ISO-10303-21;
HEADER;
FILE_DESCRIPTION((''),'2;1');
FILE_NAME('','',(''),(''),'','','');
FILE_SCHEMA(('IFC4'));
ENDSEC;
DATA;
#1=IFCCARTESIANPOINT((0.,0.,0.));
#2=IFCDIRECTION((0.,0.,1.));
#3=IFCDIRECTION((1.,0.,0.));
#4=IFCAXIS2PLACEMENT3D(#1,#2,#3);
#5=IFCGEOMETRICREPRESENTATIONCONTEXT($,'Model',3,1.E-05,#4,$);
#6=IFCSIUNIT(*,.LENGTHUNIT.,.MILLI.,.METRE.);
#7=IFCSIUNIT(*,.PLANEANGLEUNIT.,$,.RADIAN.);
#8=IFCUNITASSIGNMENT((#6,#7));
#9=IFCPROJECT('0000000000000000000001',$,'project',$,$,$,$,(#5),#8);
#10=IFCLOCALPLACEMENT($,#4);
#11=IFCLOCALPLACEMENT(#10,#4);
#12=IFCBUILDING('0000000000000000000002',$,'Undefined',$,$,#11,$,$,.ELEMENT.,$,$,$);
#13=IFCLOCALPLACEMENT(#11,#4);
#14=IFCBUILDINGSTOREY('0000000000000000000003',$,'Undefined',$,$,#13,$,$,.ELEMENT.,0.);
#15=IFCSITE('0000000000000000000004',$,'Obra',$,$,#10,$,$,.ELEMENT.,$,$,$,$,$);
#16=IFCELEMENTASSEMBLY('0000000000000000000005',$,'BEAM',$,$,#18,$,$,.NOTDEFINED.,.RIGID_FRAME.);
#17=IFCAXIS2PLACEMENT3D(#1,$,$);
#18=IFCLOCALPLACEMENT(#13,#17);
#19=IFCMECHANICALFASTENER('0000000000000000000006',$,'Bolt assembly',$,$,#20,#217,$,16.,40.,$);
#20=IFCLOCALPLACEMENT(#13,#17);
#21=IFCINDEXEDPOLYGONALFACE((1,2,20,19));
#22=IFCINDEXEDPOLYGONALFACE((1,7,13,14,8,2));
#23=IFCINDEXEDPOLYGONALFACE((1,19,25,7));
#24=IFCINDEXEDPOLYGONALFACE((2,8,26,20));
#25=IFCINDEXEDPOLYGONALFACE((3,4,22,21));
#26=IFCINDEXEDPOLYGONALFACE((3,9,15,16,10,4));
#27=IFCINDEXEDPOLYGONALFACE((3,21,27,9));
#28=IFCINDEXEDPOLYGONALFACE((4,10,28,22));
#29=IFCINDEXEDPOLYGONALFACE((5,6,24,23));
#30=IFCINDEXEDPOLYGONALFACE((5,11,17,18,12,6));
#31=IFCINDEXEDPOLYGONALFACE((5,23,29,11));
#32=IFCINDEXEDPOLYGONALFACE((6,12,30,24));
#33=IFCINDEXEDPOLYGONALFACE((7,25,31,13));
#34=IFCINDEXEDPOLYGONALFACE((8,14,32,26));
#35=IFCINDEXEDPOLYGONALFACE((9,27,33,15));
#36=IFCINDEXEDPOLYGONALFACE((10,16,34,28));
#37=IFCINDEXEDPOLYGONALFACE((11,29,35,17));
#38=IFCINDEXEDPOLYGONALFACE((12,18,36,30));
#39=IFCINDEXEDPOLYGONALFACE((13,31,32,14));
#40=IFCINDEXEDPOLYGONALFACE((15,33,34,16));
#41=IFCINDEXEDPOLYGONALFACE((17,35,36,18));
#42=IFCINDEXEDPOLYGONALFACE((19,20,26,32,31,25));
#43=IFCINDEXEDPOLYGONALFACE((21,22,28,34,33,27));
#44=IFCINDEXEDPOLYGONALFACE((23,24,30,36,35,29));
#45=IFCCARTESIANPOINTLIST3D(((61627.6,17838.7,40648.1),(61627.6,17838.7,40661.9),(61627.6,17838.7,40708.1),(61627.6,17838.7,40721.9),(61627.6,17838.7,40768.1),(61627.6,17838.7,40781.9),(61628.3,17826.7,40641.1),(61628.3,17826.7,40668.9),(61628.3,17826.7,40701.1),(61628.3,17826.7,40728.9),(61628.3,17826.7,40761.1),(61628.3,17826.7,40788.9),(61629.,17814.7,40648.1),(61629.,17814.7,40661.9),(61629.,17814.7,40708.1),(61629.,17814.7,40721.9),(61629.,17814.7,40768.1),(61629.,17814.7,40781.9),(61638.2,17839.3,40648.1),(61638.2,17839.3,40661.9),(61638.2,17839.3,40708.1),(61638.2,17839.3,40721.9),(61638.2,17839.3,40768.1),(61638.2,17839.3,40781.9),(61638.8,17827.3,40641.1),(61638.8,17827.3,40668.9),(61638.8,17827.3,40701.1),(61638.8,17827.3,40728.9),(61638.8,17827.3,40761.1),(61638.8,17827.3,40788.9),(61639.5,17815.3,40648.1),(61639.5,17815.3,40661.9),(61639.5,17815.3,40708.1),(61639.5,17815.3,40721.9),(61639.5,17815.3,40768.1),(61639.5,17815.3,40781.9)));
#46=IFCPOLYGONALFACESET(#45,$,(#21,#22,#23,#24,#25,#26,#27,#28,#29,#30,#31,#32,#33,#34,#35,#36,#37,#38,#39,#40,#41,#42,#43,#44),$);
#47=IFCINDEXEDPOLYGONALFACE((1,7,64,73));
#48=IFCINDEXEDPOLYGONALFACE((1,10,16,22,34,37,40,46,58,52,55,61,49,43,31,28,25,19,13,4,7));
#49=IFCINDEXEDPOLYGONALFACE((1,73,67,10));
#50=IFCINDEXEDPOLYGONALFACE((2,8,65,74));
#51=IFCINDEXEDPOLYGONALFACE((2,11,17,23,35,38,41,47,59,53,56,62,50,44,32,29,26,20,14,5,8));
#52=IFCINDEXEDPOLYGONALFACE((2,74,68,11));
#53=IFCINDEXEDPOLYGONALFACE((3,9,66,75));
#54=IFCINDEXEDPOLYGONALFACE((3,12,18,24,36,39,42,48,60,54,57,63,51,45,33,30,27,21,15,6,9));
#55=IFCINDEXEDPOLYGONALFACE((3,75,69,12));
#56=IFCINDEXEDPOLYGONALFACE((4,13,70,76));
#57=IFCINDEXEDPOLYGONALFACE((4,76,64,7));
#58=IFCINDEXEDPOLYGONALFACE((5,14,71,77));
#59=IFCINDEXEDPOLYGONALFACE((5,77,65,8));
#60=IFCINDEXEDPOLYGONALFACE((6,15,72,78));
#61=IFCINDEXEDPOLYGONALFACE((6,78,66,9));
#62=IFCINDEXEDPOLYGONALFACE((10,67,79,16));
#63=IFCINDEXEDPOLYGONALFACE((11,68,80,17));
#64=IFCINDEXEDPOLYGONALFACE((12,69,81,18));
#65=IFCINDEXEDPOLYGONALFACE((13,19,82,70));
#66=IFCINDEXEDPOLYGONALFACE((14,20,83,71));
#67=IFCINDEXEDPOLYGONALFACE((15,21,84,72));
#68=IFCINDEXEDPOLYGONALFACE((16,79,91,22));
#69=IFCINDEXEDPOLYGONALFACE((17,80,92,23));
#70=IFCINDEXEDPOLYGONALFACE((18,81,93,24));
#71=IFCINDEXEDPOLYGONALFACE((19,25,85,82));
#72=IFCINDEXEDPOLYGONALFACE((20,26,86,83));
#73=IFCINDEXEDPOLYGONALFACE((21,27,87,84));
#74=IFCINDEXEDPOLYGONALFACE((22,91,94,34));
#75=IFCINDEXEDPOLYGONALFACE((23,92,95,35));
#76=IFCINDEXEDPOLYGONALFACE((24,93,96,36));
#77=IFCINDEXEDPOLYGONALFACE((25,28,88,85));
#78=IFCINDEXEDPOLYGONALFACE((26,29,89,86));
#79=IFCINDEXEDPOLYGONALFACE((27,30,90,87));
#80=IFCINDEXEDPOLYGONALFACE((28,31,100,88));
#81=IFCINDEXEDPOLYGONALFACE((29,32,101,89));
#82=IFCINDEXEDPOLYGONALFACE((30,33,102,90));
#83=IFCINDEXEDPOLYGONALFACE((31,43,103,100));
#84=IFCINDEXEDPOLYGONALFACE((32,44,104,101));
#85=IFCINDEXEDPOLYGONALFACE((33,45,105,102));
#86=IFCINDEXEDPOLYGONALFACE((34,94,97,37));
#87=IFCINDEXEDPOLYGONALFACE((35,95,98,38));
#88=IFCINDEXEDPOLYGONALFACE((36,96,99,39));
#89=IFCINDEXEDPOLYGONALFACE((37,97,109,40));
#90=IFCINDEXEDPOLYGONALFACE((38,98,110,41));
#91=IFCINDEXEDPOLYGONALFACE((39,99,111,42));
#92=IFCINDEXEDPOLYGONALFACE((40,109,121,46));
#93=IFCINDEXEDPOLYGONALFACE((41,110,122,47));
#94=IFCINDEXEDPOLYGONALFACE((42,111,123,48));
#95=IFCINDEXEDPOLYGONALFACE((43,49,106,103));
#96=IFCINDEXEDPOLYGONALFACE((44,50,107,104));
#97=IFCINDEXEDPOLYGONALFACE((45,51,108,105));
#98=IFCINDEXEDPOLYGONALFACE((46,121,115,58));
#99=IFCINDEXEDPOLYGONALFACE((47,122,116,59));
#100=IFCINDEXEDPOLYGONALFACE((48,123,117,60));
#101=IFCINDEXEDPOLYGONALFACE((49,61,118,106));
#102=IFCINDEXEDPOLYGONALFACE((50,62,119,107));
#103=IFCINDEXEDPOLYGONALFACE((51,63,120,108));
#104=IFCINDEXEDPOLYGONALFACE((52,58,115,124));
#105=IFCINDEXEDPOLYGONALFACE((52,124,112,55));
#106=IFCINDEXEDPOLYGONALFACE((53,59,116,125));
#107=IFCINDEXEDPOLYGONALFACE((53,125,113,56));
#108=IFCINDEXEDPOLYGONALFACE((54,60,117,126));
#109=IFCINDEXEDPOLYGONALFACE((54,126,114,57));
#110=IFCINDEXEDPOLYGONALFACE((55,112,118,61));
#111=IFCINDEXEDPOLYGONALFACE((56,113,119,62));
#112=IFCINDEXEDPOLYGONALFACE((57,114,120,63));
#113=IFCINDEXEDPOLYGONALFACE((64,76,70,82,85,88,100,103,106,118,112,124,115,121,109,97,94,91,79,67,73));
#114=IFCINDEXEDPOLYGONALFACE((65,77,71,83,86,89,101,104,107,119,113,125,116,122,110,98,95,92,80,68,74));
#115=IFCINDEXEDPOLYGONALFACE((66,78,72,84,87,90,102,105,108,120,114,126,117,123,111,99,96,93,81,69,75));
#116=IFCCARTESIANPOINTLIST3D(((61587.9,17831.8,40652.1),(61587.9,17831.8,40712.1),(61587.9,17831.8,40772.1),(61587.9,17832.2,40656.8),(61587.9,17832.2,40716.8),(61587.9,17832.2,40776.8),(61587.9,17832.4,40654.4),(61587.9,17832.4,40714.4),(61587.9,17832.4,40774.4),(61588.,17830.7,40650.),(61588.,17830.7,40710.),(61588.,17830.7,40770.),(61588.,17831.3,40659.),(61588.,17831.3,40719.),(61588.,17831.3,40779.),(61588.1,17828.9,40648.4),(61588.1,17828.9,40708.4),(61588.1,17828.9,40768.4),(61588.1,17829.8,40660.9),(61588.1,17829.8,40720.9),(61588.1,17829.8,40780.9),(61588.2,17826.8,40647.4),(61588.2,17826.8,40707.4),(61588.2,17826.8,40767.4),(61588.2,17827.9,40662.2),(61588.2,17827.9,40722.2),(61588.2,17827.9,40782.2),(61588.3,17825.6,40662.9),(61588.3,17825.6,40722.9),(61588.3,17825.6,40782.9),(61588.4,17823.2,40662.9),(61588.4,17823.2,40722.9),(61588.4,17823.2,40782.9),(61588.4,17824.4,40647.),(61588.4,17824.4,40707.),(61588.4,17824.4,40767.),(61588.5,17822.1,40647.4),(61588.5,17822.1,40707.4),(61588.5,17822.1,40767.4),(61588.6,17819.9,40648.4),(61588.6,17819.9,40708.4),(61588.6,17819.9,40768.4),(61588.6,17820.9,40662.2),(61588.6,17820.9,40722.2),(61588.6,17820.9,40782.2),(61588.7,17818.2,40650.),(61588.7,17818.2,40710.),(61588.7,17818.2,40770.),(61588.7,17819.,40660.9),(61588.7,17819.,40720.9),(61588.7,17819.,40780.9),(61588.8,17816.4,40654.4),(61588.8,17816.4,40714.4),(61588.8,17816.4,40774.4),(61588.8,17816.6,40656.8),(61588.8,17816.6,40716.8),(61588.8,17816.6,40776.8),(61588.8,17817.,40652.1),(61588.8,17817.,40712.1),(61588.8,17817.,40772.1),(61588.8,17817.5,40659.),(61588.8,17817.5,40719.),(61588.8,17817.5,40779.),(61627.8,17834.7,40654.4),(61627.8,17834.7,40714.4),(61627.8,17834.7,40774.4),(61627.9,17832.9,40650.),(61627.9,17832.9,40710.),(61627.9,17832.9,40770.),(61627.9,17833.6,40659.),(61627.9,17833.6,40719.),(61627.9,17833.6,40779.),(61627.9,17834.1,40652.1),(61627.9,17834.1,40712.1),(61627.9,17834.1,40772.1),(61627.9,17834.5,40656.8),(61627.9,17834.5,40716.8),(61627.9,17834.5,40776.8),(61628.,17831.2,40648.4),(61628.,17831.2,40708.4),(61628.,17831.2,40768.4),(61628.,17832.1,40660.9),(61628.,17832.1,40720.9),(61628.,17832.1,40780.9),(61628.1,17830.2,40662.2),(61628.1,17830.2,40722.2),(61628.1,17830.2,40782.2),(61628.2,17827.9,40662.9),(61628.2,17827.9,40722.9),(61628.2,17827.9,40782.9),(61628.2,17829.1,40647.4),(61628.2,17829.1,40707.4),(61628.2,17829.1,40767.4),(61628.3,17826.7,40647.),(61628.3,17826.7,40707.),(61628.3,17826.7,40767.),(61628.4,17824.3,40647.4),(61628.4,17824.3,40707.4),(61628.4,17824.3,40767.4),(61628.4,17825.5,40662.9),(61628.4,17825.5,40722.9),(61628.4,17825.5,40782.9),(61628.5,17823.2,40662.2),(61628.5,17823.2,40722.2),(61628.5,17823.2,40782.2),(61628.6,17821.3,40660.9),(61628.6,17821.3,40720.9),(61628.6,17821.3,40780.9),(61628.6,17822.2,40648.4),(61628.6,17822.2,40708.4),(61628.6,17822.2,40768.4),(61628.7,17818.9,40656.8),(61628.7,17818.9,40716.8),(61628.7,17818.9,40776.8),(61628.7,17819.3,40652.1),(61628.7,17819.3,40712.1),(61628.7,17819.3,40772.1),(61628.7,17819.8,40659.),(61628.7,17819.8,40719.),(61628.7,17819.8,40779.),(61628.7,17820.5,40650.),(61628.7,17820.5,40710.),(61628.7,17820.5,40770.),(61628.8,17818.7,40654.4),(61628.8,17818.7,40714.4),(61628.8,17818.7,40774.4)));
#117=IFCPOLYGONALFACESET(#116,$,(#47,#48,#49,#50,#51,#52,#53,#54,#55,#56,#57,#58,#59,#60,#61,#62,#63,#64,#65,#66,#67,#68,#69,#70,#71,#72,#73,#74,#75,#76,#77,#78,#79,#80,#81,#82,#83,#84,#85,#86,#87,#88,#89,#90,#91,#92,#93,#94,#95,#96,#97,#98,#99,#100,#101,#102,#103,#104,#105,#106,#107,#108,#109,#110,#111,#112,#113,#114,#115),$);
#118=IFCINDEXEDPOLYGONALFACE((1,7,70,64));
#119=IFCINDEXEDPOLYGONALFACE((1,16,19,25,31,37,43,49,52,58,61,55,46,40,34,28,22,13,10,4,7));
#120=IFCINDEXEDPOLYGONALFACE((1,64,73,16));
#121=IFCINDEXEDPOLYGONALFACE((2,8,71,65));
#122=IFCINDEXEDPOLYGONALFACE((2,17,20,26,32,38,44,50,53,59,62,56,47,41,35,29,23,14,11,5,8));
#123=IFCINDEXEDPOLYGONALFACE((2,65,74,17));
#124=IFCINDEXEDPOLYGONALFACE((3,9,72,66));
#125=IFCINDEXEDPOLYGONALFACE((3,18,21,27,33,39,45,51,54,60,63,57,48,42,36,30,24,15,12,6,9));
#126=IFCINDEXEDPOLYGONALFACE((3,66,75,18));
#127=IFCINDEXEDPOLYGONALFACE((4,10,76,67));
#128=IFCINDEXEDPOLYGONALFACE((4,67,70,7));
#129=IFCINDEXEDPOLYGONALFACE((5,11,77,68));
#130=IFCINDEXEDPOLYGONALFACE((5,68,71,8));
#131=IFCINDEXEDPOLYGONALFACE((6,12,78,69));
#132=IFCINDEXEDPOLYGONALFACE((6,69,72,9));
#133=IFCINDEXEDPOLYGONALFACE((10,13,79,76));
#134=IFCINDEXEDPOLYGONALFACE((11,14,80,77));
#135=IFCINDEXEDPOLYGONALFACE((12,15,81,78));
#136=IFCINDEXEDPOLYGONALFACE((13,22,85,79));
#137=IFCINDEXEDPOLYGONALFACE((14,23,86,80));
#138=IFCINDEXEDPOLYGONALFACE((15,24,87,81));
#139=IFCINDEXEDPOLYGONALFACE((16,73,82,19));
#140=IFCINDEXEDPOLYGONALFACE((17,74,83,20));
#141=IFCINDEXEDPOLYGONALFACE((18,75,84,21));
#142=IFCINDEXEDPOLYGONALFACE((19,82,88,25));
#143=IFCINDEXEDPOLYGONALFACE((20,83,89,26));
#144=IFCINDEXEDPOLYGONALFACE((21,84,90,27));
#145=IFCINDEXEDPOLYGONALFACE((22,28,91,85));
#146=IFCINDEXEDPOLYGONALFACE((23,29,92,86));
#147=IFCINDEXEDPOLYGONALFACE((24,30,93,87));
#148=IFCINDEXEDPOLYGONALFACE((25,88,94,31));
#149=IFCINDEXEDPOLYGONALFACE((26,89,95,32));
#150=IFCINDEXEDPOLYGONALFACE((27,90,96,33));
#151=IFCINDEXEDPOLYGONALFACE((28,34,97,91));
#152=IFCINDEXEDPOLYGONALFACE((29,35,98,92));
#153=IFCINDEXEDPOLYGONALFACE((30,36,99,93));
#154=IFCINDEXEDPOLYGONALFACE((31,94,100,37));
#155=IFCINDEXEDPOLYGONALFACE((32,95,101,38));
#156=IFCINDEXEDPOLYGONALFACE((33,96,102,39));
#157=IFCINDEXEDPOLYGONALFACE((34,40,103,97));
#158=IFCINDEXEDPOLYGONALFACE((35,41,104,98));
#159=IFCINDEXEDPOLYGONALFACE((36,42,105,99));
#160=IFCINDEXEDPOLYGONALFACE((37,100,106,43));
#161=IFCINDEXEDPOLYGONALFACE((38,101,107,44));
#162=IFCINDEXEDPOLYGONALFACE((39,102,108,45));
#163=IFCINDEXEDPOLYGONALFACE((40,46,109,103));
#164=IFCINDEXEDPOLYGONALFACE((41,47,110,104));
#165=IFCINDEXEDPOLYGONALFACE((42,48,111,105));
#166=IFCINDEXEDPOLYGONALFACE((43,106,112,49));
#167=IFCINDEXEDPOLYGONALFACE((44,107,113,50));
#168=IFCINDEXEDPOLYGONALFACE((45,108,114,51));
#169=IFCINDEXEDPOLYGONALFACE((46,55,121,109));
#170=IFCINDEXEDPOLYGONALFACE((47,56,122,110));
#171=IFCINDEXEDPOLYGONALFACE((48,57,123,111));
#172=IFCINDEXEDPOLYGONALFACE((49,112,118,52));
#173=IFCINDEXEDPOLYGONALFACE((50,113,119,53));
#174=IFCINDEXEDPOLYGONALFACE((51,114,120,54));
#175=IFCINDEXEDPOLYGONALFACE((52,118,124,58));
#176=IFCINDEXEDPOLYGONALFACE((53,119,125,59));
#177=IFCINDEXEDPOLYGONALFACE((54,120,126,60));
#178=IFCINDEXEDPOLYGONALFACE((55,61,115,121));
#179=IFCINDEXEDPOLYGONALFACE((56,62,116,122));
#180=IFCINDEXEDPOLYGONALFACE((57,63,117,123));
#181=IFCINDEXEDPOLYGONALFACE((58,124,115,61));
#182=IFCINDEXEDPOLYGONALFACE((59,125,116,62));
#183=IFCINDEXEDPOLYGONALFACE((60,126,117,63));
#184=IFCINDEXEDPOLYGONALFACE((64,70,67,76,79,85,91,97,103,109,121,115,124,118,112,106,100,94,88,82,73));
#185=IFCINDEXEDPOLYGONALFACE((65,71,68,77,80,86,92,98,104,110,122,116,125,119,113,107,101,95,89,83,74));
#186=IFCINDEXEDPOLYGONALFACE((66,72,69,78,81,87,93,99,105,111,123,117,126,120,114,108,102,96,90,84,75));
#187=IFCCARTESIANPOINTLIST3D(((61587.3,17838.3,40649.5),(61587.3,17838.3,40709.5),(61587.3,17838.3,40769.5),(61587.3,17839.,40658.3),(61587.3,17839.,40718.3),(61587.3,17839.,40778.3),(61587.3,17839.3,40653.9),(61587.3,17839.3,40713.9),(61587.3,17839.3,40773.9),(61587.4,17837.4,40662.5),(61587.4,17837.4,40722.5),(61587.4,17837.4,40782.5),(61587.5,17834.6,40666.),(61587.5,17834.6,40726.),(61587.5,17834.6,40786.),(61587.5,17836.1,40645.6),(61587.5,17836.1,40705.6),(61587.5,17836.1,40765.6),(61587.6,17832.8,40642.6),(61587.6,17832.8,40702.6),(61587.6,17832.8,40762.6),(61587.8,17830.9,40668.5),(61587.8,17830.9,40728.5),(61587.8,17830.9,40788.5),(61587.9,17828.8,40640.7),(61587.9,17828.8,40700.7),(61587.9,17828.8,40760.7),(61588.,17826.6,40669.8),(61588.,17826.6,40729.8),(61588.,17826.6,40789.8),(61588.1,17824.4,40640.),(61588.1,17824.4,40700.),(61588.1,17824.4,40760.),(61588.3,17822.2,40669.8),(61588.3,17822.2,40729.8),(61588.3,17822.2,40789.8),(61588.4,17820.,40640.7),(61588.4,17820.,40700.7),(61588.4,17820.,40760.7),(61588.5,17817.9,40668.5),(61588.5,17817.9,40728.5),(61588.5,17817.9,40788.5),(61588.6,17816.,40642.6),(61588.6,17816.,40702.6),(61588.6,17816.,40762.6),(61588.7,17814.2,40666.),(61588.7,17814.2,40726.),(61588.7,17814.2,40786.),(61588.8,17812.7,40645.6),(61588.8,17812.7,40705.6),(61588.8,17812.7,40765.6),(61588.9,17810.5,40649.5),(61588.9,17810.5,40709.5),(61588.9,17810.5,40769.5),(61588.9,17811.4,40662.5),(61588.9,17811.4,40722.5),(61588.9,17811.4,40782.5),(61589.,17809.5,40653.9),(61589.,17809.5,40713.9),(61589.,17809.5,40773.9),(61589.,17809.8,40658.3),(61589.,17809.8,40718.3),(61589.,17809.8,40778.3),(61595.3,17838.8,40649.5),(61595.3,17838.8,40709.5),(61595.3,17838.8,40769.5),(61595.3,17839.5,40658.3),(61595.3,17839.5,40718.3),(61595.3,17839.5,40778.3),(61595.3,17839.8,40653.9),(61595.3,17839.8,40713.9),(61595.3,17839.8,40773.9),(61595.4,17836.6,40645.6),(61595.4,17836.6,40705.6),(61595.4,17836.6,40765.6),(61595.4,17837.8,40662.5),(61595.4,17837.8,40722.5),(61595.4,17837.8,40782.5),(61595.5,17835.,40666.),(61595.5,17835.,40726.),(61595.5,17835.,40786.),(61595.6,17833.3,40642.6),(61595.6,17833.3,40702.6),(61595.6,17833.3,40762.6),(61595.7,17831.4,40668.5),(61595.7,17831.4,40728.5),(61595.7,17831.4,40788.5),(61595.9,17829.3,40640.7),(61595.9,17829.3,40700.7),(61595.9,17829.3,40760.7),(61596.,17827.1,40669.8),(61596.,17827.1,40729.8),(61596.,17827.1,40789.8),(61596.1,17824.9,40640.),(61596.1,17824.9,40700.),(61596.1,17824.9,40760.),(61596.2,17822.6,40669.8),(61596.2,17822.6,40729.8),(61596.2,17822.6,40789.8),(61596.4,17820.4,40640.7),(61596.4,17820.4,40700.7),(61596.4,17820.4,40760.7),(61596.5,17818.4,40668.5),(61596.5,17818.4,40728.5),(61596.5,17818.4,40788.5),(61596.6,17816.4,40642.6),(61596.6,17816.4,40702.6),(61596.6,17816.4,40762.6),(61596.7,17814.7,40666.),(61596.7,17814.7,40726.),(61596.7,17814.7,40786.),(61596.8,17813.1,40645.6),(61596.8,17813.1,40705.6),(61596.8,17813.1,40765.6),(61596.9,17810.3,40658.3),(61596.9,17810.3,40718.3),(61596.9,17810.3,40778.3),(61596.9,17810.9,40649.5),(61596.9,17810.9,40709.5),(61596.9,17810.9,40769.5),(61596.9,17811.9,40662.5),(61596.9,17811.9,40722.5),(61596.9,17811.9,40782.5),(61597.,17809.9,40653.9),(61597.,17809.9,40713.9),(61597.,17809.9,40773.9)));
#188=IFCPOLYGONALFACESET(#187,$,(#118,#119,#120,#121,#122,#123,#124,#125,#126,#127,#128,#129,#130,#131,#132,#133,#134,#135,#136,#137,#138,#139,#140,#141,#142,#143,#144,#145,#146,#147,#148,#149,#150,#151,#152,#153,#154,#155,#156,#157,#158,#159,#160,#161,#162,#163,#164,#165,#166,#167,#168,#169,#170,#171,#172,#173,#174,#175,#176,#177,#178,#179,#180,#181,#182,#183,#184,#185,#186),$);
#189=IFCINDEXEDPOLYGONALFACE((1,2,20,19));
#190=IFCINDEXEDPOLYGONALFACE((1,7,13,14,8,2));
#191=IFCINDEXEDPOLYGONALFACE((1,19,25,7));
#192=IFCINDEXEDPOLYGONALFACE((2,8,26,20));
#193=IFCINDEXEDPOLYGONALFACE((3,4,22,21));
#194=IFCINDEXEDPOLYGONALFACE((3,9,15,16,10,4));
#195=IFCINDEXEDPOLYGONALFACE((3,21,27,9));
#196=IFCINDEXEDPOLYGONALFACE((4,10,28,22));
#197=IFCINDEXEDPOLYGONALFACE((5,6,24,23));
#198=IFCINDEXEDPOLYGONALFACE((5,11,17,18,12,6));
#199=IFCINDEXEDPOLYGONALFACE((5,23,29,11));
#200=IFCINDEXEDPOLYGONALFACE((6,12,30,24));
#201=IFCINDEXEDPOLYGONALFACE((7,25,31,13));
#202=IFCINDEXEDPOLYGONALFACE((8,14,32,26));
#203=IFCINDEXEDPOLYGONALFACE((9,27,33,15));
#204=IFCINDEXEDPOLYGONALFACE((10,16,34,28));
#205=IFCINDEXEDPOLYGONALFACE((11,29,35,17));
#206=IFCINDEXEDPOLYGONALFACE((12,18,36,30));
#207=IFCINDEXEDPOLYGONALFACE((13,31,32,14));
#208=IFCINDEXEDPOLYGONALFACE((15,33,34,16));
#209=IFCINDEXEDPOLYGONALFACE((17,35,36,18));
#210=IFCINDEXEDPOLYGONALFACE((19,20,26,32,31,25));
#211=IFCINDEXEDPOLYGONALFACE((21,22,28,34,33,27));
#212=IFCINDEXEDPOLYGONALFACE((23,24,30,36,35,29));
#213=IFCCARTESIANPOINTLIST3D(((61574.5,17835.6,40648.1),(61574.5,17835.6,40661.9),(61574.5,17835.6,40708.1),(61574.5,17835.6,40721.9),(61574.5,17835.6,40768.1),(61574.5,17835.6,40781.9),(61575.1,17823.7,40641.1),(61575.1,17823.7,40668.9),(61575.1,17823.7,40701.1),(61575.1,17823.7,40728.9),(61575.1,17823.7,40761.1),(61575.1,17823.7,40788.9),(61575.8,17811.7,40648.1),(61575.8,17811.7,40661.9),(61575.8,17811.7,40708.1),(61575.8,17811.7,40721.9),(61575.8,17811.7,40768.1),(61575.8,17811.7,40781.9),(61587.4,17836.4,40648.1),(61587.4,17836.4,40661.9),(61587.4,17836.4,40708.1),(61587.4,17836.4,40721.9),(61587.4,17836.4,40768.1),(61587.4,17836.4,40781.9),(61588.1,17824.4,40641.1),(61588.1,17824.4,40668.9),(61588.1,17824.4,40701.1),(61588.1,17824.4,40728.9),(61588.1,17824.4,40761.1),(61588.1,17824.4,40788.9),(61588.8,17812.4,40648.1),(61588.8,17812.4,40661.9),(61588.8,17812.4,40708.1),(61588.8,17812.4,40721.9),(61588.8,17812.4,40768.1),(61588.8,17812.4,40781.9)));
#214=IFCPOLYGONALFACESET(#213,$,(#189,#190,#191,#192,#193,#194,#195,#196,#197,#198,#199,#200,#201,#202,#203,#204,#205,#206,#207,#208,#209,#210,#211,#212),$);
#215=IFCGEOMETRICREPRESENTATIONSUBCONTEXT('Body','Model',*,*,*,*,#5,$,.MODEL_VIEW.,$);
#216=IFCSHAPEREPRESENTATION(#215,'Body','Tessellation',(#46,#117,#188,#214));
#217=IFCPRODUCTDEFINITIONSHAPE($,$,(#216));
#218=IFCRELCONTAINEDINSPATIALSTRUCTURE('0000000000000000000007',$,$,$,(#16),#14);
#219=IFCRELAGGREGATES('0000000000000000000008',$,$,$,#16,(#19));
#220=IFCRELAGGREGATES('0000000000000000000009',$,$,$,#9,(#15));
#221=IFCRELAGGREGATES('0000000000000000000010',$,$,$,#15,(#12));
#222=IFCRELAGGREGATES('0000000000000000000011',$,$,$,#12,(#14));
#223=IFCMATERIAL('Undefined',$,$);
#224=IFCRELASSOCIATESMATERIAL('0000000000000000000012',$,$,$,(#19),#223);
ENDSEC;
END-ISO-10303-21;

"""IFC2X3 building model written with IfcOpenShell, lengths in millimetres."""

from ifc_helpers import new_model, si_unit, frame, origin_with_axes, origin_2d_with_axis, place, context, subcontext, project, spatial, polyline, circle, outline, extrude, source, transform, mapped, material, element, aggregate, save


model = new_model("IFC2X3")

# Units and contexts
model_context = context("Model", 3, precision=1e-05, world=origin_with_axes())
body_context = subcontext(model_context, "Body", "Model", "MODEL_VIEW")
ifc_project = project(units=[si_unit("LENGTHUNIT", "METRE", prefix="MILLI"), si_unit("PLANEANGLEUNIT", "RADIAN")], contexts=[model_context])

# Site, building, storey
site_placement = place(None, origin_with_axes())
site = spatial("IfcSite", under=ifc_project, at=site_placement, Name="Obra", CompositionType="ELEMENT")
building_placement = place(site_placement, origin_with_axes())
building = spatial("IfcBuilding", under=site, at=building_placement, Name="Undefined", CompositionType="ELEMENT")
storey_placement = place(building_placement, origin_with_axes())
storey = spatial("IfcBuildingStorey", under=building, at=storey_placement, Name="Undefined", CompositionType="ELEMENT", Elevation=0.0)

# Element assembly
assembly_1_placement = place(storey_placement, origin_with_axes())
assembly_1 = element("IfcElementAssembly", 1, at=assembly_1_placement, inside=storey, Name="BEAM", AssemblyPlace="NOTDEFINED", PredefinedType="RIGID_FRAME")

# Mechanical fastener
ifc_material_1 = material(Name="Undefined")
shared_shape_1 = source(origin_with_axes(), body_context, "Body", "SweptSolid", [
    extrude(outline(polyline([(13.9, 0.0), (6.9, 12.0), (-6.9, 12.0), (-13.9, 0.0), (-6.9, -12.0), (6.9, -12.0), (13.9, 0.0)])), frame((0.0, -45.9, 0.0), z_axis=(0.0, 1.0, 0.0), x_axis=(1.0, 0.0, 0.0)), (0.0, 0.0, 1.0), 10.6),
    extrude(circle(Radius=8.0, at=origin_2d_with_axis()), frame((0.0, -35.3, 0.0), z_axis=(0.0, 1.0, 0.0), x_axis=(1.0, 0.0, 0.0)), (0.0, 0.0, 1.0), 40.0),
    extrude(circle(Radius=15.0, at=origin_2d_with_axis()), frame((0.0, -3.1, 0.0), z_axis=(0.0, 1.0, 0.0), x_axis=(1.0, 0.0, 0.0)), (0.0, 0.0, 1.0), 8.0),
    extrude(outline(polyline([(13.9, 0.0), (6.9, 12.0), (-6.9, 12.0), (-13.9, 0.0), (-6.9, -12.0), (6.9, -12.0), (13.9, 0.0)])), frame((0.0, 4.9, 0.0), z_axis=(0.0, 1.0, 0.0), x_axis=(1.0, 0.0, 0.0)), (0.0, 0.0, 1.0), 13.0),
])
mechanical_fastener_1_placement = place(assembly_1_placement, frame((61595.9, 17774.8, 40835.0), z_axis=(-0.057107, 0.998368, 0.0), x_axis=(0.0, 0.0, -1.0)))
mechanical_fastener_1 = element("IfcMechanicalFastener", 2, at=mechanical_fastener_1_placement, material=ifc_material_1, Name="Bolt assembly", NominalDiameter=16.0, NominalLength=40.0, context=body_context, shape_type="MappedRepresentation", body=[
    mapped(shared_shape_1, transform((60.0, 0.0, 50.0))),
    mapped(shared_shape_1, transform((120.0, 0.0, 50.0))),
    mapped(shared_shape_1, transform((180.0, 0.0, 50.0))),
])
aggregate(assembly_1, [mechanical_fastener_1])

save(model, "model.ifc")
